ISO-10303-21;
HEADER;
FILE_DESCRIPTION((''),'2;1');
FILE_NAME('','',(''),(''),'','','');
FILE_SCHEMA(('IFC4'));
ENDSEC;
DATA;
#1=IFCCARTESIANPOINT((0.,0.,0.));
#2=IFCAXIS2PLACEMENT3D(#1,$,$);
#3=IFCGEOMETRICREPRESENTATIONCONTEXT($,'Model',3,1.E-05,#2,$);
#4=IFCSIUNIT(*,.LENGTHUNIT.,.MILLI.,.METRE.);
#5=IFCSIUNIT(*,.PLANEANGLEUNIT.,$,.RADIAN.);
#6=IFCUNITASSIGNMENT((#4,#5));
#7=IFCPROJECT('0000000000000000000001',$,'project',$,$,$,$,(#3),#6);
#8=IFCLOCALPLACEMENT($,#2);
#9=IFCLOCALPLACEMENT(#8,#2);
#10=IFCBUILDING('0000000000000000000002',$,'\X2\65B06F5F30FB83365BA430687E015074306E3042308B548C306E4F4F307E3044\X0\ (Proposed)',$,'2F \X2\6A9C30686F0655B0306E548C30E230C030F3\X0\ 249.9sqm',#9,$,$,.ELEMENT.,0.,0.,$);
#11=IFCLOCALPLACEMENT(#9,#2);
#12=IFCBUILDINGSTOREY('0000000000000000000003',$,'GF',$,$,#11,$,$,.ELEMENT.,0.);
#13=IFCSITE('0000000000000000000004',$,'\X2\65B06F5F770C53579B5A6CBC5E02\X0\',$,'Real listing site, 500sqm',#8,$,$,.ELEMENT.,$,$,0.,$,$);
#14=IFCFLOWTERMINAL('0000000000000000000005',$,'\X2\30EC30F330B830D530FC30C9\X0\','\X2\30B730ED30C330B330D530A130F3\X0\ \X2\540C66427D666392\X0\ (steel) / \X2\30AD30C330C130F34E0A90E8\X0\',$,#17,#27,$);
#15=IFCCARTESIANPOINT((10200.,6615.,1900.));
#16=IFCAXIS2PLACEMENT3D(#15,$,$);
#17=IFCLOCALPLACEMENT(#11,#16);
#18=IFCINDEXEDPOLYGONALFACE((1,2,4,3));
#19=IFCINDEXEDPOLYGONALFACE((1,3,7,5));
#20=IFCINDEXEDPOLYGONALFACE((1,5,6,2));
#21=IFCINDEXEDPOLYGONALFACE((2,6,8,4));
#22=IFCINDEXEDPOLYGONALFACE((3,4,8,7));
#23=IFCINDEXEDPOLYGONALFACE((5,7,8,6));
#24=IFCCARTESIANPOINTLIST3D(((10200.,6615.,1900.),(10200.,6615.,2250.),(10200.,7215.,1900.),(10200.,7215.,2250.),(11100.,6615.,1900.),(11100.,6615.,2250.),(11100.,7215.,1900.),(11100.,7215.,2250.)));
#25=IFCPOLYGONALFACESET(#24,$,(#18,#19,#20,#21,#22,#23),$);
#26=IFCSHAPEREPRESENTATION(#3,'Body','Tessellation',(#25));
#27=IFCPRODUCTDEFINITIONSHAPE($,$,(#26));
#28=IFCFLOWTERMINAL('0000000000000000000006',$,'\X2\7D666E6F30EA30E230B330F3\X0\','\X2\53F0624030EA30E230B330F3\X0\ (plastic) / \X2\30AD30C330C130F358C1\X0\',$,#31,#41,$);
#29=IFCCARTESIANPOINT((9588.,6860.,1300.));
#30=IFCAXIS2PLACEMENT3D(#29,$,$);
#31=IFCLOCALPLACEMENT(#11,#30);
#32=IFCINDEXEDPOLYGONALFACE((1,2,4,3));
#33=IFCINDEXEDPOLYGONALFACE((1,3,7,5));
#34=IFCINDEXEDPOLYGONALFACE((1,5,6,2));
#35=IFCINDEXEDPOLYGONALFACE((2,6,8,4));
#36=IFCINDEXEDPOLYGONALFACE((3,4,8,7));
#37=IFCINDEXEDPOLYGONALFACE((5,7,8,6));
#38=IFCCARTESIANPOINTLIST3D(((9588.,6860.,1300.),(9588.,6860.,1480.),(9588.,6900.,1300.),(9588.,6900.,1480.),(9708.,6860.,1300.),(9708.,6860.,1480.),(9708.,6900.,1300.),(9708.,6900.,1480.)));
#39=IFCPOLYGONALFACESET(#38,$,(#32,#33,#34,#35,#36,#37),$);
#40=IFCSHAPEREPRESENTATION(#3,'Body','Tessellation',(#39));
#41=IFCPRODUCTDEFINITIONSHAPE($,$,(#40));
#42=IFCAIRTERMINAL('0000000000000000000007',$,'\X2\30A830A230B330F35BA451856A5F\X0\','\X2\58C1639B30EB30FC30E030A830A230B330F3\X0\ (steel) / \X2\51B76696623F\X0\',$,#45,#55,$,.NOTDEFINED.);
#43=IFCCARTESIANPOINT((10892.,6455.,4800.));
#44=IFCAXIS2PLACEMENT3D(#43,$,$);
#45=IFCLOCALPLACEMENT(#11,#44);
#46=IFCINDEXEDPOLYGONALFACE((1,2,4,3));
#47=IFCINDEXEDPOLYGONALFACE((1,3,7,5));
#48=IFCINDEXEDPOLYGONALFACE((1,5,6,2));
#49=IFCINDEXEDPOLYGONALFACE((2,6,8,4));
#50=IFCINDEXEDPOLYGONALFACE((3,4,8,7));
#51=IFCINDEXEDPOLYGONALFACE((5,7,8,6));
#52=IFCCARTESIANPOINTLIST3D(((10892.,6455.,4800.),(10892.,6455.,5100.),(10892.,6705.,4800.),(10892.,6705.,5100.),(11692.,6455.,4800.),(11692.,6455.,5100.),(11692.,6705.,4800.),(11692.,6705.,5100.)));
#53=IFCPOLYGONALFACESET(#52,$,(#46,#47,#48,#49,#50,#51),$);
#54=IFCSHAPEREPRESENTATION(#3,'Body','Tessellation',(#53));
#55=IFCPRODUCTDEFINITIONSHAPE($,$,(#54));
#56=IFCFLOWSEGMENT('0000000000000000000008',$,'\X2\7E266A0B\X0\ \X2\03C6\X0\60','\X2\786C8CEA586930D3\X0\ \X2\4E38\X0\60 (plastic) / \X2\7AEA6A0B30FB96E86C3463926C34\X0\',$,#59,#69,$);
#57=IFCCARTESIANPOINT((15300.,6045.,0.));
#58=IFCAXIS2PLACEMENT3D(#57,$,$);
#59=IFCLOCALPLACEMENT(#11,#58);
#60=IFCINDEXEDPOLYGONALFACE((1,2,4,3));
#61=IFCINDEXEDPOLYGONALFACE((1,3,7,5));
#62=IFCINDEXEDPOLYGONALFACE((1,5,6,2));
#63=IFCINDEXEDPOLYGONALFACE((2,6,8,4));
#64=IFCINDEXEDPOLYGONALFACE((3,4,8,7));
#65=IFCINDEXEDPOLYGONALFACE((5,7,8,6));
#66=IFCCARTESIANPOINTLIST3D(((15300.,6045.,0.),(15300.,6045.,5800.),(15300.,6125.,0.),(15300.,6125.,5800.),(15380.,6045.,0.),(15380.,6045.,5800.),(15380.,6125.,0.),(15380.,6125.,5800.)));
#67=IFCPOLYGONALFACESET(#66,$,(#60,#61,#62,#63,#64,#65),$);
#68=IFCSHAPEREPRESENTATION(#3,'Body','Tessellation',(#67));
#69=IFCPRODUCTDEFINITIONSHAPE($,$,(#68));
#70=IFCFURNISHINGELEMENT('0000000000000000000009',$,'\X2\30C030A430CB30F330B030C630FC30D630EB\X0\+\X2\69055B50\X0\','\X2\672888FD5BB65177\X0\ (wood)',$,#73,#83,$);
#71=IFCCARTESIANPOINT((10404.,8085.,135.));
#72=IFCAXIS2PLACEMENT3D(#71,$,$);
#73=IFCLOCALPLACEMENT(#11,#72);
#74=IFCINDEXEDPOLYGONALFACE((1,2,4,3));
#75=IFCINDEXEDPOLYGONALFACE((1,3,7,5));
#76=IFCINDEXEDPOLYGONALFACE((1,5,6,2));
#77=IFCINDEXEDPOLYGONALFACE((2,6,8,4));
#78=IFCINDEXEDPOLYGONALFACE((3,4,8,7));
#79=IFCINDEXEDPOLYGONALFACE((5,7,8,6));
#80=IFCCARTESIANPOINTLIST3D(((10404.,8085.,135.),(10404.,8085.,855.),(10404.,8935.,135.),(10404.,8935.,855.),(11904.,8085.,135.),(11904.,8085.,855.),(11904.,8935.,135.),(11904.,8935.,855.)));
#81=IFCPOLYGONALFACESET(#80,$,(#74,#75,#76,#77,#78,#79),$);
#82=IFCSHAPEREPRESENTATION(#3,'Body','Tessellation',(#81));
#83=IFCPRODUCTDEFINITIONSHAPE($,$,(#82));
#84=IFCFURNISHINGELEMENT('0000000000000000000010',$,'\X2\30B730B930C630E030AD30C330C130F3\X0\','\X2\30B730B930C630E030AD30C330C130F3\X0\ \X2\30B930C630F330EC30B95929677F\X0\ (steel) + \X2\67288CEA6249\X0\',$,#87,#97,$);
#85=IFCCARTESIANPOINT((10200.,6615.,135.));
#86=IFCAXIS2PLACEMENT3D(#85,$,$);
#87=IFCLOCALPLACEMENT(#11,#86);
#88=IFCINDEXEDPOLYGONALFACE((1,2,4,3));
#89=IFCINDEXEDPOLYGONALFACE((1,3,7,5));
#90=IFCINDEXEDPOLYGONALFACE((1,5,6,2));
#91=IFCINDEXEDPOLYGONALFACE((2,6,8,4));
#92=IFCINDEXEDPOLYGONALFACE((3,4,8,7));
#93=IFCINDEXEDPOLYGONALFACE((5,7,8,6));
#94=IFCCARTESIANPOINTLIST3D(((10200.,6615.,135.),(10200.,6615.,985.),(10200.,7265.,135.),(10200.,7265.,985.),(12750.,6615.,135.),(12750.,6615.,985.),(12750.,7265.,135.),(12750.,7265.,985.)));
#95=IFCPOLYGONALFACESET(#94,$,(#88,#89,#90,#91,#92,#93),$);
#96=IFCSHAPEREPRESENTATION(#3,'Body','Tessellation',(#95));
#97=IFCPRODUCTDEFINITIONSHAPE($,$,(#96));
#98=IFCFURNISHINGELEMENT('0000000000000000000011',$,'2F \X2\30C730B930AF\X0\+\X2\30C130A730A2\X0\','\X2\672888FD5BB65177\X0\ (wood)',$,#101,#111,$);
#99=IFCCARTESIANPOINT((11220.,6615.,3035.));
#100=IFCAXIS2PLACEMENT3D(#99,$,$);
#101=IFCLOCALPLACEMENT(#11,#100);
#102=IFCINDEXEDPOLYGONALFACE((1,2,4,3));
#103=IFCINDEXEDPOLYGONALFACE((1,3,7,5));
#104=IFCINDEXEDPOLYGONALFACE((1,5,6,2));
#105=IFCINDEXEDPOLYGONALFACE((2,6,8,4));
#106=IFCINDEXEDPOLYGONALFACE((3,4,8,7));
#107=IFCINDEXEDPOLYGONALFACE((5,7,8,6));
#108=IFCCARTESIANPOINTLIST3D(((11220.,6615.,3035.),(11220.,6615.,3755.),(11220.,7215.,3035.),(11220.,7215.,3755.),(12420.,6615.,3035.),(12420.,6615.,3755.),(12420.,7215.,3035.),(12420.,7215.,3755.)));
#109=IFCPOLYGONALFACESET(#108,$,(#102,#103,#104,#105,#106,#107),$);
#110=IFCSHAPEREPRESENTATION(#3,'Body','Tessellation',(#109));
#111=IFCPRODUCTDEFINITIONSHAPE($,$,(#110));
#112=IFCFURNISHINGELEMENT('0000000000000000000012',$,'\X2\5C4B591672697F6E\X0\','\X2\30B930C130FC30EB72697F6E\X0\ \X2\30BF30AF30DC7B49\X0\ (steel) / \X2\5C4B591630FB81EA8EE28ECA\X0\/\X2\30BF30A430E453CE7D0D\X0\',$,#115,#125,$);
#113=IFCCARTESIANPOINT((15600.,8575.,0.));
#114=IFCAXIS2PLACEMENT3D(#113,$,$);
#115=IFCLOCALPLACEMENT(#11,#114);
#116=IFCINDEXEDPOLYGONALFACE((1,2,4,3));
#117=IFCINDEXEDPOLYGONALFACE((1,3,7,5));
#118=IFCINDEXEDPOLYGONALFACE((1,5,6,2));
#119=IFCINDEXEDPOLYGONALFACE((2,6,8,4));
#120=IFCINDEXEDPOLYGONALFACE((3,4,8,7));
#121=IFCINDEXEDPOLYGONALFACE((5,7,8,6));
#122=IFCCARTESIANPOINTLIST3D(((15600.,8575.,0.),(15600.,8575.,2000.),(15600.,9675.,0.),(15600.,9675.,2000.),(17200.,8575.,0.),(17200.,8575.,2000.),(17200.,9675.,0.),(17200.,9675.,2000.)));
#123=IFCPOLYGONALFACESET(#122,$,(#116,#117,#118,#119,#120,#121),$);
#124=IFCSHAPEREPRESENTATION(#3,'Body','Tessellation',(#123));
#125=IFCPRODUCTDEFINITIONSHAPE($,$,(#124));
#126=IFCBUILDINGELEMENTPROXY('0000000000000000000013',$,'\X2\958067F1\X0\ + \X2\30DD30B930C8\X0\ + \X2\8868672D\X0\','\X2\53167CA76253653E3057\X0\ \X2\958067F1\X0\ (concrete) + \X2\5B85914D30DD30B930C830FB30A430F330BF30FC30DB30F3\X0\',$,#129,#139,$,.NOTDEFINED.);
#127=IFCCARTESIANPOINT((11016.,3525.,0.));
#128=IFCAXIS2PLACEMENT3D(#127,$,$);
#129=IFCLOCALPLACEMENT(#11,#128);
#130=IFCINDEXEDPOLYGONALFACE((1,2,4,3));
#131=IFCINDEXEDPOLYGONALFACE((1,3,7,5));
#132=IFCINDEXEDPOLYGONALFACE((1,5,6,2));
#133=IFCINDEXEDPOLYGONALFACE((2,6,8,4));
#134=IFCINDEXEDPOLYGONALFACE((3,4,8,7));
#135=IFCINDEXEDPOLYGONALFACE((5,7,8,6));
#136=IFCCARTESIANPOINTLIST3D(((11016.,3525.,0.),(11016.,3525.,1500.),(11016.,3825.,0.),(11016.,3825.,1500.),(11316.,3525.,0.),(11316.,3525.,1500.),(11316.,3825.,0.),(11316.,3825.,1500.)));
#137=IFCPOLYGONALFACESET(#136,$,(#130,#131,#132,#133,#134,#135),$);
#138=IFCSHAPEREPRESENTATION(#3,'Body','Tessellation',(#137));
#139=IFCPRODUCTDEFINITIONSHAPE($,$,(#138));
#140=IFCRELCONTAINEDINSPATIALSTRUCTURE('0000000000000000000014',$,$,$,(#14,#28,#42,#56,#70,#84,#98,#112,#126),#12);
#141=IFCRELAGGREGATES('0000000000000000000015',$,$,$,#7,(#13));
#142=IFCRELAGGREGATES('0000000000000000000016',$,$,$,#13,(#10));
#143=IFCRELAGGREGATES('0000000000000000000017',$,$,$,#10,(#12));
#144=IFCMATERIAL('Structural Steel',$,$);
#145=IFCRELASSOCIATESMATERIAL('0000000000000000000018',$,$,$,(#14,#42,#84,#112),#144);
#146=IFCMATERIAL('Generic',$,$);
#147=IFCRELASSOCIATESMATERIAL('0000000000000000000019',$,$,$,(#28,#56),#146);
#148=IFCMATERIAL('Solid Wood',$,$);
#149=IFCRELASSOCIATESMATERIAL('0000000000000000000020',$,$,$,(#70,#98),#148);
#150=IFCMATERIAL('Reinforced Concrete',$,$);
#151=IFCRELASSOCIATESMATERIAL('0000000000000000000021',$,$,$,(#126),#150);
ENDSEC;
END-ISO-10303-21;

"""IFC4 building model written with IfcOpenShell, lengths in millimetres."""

from ifc_helpers import new_model, si_unit, frame, frame_2d, origin, place, context, project, spatial, rectangle, extrude, material, element, save


model = new_model("IFC4")

# Units and contexts
model_context = context("Model", 3, precision=1e-05, world=origin())
ifc_project = project(units=[si_unit("LENGTHUNIT", "METRE", prefix="MILLI"), si_unit("PLANEANGLEUNIT", "RADIAN")], contexts=[model_context])

# Site, building, storey
site_placement = place(None, origin())
site = spatial("IfcSite", under=ifc_project, at=site_placement, Name="新潟県南魚沼市", ObjectType="Real listing site, 500sqm", CompositionType="ELEMENT", RefElevation=0.0)
building_placement = place(site_placement, origin())
building = spatial("IfcBuilding", under=site, at=building_placement, Name="新潟・茶室と縁側のある和の住まい (Proposed)", ObjectType="2F 檜と漆喰の和モダン 249.9sqm", CompositionType="ELEMENT", ElevationOfRefHeight=0.0, ElevationOfTerrain=0.0)
storey_placement = place(building_placement, origin())
storey = spatial("IfcBuildingStorey", under=building, at=storey_placement, Name="GF", CompositionType="ELEMENT", Elevation=0.0)

# Shared definitions
ifc_material_1 = material(Name="Solid Wood")

# Shared definitions
ifc_material_2 = material(Name="Reinforced Concrete")

# Shared definitions
ifc_material_3 = material(Name="Structural Steel")

# Flow terminals
flow_terminal_1_placement = place(storey_placement, frame((10200.0, 6615.0, 1900.0)))
element("IfcFlowTerminal", 1, at=flow_terminal_1_placement, inside=storey, material=ifc_material_3, Name="レンジフード", Description="シロッコファン 同時給排 (steel) / キッチン上部", context=model_context, shape_type="SweptSolid", body=[
    extrude(rectangle(XDim=900.0, YDim=600.0, at=frame_2d((450.0, 300.0))), frame((10200.0, 6615.0, 1900.0)), (0.0, 0.0, 1.0), 350.0),
])
ifc_material_4 = material(Name="Generic")
flow_terminal_2_placement = place(storey_placement, frame((9588.0, 6860.0, 1300.0)))
element("IfcFlowTerminal", 2, at=flow_terminal_2_placement, inside=storey, material=ifc_material_4, Name="給湯リモコン", Description="台所リモコン (plastic) / キッチン壁", context=model_context, shape_type="SweptSolid", body=[
    extrude(rectangle(XDim=120.0, YDim=40.0, at=frame_2d((60.0, 20.0))), frame((9588.0, 6860.0, 1300.0)), (0.0, 0.0, 1.0), 180.0),
])

# Air terminal
air_terminal_placement = place(storey_placement, frame((10892.0, 6455.0, 4800.0)))
element("IfcAirTerminal", 3, at=air_terminal_placement, inside=storey, material=ifc_material_3, Name="エアコン室内機", Description="壁掛ルームエアコン (steel) / 冷暖房", PredefinedType="NOTDEFINED", context=model_context, shape_type="SweptSolid", body=[
    extrude(rectangle(XDim=800.0, YDim=250.0, at=frame_2d((400.0, 125.0))), frame((10892.0, 6455.0, 4800.0)), (0.0, 0.0, 1.0), 300.0),
])

# Flow segment
flow_segment_placement = place(storey_placement, frame((15300.0, 6045.0, 0.0)))
element("IfcFlowSegment", 4, at=flow_segment_placement, inside=storey, material=ifc_material_4, Name="縦樋 φ60", Description="硬質塩ビ 丸60 (plastic) / 竪樋・雨水排水", context=model_context, shape_type="SweptSolid", body=[
    extrude(rectangle(XDim=80.0, YDim=80.0, at=frame_2d((40.0, 40.0))), frame((15300.0, 6045.0, 0.0)), (0.0, 0.0, 1.0), 5800.0),
])

# Furnishing elements
furnishing_1_placement = place(storey_placement, frame((10404.0, 8085.0, 135.0)))
element("IfcFurnishingElement", 5, at=furnishing_1_placement, inside=storey, material=ifc_material_1, Name="ダイニングテーブル+椅子", Description="木製家具 (wood)", context=model_context, shape_type="SweptSolid", body=[
    extrude(rectangle(XDim=1500.0, YDim=850.0, at=frame_2d((750.0, 425.0))), frame((10404.0, 8085.0, 135.0)), (0.0, 0.0, 1.0), 720.0),
])
furnishing_2_placement = place(storey_placement, frame((10200.0, 6615.0, 135.0)))
element("IfcFurnishingElement", 6, at=furnishing_2_placement, inside=storey, material=ifc_material_3, Name="システムキッチン", Description="システムキッチン ステンレス天板 (steel) + 木質扉", context=model_context, shape_type="SweptSolid", body=[
    extrude(rectangle(XDim=2550.0, YDim=650.0, at=frame_2d((1275.0, 325.0))), frame((10200.0, 6615.0, 135.0)), (0.0, 0.0, 1.0), 850.0),
])
furnishing_3_placement = place(storey_placement, frame((11220.0, 6615.0, 3035.0)))
element("IfcFurnishingElement", 7, at=furnishing_3_placement, inside=storey, material=ifc_material_1, Name="2F デスク+チェア", Description="木製家具 (wood)", context=model_context, shape_type="SweptSolid", body=[
    extrude(rectangle(XDim=1200.0, YDim=600.0, at=frame_2d((600.0, 300.0))), frame((11220.0, 6615.0, 3035.0)), (0.0, 0.0, 1.0), 720.0),
])
furnishing_4_placement = place(storey_placement, frame((15600.0, 8575.0, 0.0)))
element("IfcFurnishingElement", 8, at=furnishing_4_placement, inside=storey, material=ifc_material_3, Name="屋外物置", Description="スチール物置 タクボ等 (steel) / 屋外・自転車/タイヤ収納", context=model_context, shape_type="SweptSolid", body=[
    extrude(rectangle(XDim=1600.0, YDim=1100.0, at=frame_2d((800.0, 550.0))), frame((15600.0, 8575.0, 0.0)), (0.0, 0.0, 1.0), 2000.0),
])

# Building element proxy
proxy_placement = place(storey_placement, frame((11016.0, 3525.0, 0.0)))
element("IfcBuildingElementProxy", 9, at=proxy_placement, inside=storey, material=ifc_material_2, Name="門柱 + ポスト + 表札", Description="化粧打放し 門柱 (concrete) + 宅配ポスト・インターホン", PredefinedType="NOTDEFINED", context=model_context, shape_type="SweptSolid", body=[
    extrude(rectangle(XDim=300.0, YDim=300.0, at=frame_2d((150.0, 150.0))), frame((11016.0, 3525.0, 0.0)), (0.0, 0.0, 1.0), 1500.0),
])

save(model, "model.ifc")
